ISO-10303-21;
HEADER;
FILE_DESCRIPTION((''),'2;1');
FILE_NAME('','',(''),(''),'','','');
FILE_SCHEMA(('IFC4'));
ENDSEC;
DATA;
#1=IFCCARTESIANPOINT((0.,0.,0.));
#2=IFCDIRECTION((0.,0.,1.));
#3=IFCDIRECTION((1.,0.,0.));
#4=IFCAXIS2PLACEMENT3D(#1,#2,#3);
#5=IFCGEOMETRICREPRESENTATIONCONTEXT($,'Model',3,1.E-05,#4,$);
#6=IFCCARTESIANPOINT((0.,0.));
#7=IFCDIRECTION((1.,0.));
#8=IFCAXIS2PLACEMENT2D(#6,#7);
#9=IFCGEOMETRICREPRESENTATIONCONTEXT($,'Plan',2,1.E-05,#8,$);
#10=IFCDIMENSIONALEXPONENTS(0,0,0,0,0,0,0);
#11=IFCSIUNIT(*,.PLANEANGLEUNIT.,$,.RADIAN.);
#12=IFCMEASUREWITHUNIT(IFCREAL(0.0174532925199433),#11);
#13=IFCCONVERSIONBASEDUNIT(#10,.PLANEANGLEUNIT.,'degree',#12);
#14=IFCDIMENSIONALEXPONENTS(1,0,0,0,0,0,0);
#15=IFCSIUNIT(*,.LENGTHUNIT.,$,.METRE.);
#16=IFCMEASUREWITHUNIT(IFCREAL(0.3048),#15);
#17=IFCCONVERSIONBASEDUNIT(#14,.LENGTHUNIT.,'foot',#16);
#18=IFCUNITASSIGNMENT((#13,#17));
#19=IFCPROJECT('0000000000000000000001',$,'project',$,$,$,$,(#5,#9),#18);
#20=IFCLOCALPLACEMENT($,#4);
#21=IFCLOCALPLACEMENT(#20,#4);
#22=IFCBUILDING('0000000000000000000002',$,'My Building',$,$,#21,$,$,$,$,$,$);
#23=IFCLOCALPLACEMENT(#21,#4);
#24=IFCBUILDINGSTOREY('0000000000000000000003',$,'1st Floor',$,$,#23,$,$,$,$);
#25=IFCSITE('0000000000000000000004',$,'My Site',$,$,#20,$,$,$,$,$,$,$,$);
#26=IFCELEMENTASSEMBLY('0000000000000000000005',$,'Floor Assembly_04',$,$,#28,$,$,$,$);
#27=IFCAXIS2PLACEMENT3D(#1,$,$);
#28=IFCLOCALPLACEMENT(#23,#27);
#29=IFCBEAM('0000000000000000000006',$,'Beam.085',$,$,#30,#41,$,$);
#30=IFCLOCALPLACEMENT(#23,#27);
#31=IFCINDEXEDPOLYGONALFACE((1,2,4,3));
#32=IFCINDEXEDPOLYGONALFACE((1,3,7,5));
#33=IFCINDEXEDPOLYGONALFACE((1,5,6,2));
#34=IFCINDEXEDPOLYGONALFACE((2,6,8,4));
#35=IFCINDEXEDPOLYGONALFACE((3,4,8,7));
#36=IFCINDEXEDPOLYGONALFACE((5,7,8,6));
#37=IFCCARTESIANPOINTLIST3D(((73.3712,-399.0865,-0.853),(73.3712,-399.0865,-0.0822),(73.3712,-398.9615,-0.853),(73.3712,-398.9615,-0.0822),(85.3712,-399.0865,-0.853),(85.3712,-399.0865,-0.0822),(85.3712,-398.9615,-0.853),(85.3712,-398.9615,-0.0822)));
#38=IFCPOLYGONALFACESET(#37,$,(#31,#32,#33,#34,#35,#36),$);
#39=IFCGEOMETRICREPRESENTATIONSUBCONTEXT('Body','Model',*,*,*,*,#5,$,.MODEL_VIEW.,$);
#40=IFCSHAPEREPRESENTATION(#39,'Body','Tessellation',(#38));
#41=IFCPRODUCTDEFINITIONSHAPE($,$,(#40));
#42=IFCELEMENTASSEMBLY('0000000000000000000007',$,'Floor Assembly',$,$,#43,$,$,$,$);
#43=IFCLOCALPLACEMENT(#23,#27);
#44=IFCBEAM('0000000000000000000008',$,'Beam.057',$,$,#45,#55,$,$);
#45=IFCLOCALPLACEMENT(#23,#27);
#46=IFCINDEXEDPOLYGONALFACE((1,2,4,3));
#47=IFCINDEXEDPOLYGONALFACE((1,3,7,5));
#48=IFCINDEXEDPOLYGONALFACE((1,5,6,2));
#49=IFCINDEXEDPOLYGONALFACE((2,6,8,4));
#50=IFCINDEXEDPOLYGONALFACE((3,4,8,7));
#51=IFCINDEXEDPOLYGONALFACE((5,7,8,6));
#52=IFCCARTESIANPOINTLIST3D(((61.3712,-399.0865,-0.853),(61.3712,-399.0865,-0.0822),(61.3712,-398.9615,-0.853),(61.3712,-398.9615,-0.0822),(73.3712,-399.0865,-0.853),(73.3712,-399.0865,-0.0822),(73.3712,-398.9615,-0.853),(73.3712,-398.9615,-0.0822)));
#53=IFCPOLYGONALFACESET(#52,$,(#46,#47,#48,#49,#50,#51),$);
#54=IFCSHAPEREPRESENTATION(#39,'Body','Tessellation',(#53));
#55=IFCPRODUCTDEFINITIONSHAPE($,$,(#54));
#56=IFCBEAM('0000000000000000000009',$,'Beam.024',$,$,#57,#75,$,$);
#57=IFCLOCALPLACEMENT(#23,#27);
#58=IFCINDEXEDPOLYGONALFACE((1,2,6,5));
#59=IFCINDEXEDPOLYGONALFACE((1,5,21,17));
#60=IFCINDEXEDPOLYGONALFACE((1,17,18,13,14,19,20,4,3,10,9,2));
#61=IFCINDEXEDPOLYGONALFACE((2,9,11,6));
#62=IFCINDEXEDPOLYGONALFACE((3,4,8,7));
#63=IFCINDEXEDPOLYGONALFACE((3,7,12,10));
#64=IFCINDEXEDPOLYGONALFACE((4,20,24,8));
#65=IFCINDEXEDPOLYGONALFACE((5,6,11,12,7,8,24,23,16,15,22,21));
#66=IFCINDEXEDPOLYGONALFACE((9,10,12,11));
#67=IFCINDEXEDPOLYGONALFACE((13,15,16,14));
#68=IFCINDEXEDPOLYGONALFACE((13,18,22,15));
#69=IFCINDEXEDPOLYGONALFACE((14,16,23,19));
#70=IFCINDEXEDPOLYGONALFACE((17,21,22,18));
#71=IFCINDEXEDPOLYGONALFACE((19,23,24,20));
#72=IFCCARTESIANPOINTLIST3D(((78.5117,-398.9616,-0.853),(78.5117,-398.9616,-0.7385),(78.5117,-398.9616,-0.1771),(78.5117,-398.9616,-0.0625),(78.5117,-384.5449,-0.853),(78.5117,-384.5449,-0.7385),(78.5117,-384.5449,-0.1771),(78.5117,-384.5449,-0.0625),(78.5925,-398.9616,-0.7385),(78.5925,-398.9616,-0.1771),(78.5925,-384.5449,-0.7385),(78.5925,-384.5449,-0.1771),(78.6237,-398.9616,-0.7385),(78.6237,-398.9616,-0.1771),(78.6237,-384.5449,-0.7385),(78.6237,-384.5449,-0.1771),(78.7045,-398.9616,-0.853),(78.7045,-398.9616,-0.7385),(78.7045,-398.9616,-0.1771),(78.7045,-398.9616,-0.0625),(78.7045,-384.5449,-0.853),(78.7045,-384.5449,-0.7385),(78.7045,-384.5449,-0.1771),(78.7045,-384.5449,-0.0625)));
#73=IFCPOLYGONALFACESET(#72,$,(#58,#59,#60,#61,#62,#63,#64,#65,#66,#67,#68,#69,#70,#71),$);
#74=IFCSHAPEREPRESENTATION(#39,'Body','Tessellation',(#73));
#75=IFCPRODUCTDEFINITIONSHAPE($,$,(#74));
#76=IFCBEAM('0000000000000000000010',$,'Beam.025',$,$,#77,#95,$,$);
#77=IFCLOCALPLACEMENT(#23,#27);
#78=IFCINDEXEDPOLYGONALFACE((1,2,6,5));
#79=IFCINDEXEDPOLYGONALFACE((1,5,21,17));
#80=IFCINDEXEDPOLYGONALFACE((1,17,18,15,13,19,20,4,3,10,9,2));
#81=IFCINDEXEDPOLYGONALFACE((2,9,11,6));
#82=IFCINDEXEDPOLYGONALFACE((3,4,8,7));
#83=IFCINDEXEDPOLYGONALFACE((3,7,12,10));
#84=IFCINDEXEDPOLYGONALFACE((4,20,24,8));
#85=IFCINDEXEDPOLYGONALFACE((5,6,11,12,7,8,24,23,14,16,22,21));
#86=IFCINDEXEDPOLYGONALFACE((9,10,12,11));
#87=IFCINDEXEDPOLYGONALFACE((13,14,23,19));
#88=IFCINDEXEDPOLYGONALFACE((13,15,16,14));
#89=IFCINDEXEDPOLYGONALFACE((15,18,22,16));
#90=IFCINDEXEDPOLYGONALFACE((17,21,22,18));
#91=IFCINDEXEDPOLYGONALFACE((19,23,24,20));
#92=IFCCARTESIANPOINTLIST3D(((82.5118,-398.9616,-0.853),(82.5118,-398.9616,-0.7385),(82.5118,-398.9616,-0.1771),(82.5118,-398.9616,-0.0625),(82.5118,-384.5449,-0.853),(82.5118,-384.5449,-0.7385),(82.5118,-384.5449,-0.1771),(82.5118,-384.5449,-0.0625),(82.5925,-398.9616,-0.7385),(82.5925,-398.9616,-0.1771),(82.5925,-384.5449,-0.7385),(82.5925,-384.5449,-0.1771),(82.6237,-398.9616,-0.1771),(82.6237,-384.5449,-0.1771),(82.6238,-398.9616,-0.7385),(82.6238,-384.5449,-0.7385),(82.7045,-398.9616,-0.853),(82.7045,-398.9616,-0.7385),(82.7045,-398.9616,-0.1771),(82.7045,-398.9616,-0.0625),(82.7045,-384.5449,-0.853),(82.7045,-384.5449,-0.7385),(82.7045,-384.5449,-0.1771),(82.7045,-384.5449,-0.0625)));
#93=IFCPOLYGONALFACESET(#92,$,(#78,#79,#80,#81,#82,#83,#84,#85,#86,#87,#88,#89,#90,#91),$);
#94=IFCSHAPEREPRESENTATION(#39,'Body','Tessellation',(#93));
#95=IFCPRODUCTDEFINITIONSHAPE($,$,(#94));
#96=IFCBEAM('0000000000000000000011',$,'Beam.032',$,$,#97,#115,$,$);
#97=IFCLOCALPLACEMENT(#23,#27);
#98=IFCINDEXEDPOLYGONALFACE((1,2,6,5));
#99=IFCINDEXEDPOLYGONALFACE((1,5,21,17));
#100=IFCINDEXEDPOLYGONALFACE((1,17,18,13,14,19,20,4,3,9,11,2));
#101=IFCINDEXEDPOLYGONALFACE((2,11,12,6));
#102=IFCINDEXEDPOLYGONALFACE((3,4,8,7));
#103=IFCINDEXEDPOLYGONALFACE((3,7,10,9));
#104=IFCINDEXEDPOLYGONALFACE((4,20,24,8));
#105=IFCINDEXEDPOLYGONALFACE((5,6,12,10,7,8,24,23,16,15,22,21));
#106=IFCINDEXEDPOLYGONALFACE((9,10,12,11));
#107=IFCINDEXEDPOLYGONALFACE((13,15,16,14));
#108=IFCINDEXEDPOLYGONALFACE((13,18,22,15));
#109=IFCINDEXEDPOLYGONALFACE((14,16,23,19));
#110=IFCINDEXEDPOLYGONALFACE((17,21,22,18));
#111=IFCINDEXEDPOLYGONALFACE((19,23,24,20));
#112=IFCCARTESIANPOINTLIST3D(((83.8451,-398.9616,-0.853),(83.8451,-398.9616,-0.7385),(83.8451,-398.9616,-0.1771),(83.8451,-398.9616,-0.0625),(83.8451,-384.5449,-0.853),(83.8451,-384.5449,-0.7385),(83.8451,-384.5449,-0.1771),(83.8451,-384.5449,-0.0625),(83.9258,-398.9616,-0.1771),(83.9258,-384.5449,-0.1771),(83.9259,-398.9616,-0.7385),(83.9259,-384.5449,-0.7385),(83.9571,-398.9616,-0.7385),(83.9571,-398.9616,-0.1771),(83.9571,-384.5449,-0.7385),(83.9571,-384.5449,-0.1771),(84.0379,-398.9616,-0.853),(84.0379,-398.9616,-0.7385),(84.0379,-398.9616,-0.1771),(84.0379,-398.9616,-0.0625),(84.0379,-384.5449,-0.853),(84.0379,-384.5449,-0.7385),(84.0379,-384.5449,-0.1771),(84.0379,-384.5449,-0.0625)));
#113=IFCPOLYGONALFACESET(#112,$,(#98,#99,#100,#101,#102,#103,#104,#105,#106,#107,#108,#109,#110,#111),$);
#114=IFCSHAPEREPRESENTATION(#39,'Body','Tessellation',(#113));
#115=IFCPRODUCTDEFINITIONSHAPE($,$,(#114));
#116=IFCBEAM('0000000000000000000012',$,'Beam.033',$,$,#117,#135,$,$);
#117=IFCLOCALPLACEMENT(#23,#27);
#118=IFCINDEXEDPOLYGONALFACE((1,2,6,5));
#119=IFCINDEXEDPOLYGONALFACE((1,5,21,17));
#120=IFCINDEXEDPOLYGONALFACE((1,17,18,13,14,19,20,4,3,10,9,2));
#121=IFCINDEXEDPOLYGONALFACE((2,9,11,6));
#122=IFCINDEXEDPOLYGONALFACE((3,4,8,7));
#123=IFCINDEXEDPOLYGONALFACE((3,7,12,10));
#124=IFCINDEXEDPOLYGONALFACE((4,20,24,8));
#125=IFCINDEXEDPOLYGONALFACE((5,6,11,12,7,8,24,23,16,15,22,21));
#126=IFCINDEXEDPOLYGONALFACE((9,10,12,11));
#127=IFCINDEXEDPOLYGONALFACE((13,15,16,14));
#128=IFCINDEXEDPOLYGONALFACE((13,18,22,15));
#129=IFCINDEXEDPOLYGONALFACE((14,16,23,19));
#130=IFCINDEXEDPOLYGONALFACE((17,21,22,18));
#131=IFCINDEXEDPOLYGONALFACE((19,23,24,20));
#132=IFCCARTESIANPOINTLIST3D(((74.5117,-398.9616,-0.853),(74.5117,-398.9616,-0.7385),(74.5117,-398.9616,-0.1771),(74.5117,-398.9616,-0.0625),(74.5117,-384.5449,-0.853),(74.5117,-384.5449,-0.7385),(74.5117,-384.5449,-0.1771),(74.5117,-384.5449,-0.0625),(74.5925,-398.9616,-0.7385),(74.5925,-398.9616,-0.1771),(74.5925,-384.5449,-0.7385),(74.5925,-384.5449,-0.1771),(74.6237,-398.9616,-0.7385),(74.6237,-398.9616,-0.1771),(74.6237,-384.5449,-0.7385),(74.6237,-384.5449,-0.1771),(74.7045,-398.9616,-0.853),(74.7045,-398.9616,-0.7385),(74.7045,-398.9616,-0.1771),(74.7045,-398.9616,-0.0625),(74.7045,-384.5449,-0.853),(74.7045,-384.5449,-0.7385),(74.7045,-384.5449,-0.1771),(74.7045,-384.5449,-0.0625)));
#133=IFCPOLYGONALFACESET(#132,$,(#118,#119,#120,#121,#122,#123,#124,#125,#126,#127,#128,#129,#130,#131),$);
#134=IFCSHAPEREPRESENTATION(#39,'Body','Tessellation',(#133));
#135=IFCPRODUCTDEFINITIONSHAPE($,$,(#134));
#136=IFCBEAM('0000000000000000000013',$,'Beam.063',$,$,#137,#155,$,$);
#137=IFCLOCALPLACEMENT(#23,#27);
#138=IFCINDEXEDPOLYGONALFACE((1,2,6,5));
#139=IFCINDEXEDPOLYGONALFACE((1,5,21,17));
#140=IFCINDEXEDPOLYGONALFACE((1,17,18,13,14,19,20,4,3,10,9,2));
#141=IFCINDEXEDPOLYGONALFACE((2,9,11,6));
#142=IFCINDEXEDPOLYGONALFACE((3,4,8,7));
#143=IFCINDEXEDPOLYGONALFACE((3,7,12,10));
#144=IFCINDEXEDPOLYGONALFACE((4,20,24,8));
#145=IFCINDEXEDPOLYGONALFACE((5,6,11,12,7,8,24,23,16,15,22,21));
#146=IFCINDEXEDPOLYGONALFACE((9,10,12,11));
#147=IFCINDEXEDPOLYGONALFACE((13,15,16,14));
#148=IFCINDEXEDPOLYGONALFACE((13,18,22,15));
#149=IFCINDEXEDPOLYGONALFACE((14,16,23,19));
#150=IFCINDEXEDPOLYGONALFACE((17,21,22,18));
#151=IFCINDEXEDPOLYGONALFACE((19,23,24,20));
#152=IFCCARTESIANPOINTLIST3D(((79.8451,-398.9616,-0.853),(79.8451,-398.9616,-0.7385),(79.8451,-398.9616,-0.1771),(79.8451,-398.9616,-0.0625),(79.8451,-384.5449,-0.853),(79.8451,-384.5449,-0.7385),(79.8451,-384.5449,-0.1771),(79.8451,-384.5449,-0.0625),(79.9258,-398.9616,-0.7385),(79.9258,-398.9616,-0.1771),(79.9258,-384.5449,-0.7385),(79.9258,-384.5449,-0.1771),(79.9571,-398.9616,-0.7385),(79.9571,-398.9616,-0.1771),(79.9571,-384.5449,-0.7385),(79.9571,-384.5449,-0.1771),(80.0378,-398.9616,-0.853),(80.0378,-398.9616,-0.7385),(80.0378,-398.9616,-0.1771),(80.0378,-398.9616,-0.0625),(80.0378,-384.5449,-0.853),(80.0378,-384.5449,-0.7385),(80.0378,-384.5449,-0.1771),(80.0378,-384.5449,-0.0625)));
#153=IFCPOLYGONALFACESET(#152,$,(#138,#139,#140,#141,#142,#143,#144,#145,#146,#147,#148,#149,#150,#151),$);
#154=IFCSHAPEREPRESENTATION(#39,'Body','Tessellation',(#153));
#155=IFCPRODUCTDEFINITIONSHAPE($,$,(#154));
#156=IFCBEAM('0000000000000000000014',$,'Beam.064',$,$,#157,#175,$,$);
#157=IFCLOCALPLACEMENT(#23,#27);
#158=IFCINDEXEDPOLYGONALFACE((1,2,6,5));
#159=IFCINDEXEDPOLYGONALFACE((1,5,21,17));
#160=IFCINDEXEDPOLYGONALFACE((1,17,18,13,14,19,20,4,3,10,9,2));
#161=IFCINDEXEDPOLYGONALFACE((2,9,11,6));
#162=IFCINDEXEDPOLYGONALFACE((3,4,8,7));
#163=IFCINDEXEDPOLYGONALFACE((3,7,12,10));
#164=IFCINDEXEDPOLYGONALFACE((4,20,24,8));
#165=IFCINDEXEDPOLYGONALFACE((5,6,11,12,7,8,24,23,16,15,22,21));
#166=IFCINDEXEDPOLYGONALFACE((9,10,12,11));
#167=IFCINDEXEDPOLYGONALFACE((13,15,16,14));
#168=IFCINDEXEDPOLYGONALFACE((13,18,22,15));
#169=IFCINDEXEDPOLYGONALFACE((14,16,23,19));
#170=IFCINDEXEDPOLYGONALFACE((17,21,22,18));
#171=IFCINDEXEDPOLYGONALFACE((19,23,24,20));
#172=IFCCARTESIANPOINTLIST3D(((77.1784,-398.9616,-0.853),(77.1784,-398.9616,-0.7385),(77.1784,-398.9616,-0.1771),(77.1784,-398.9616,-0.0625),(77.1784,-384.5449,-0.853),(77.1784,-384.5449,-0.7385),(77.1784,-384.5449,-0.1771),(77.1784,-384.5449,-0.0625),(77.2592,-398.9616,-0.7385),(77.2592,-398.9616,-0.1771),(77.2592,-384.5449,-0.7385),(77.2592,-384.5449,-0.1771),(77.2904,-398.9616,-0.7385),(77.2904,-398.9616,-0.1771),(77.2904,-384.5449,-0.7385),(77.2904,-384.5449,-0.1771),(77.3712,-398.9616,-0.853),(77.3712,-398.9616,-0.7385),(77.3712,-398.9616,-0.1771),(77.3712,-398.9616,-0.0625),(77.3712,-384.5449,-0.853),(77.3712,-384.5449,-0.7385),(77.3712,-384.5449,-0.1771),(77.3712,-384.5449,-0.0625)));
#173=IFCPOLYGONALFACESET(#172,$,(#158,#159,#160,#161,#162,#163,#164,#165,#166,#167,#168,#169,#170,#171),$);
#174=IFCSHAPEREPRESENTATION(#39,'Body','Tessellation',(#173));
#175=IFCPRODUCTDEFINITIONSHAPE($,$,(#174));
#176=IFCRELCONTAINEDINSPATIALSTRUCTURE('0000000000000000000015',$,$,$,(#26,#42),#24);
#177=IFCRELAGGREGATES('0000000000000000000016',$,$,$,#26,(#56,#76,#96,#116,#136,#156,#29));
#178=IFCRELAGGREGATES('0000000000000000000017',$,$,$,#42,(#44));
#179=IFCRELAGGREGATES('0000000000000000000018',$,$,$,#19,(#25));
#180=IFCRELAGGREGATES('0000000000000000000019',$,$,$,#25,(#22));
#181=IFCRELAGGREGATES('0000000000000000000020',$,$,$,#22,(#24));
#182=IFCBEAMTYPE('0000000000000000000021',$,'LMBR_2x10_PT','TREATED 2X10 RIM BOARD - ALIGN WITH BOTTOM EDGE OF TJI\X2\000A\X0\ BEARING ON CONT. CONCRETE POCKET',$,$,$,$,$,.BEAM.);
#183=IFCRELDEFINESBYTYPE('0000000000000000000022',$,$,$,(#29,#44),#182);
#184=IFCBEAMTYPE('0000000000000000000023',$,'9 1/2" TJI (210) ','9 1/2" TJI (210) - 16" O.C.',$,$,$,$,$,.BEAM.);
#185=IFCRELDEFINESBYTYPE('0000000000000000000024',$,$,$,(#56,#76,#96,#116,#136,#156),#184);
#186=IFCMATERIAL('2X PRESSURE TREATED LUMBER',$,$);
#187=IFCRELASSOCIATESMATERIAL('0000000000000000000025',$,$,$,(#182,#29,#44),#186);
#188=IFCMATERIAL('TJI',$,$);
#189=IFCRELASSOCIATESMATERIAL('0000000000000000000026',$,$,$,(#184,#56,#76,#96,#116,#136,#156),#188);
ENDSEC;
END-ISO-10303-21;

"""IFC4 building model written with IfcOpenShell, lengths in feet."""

from ifc_helpers import new_model, entity, si_unit, converted_unit, frame, origin_with_axes, origin_2d_with_axis, place, context, subcontext, project, spatial, indexed_curve, outline, extrude, material, material_profile, profile_set, profile_usage, type_object, element, aggregate, save


model = new_model("IFC4")

# Units and contexts
model_context = context("Model", 3, precision=1e-05, world=origin_with_axes())
plan_context = context("Plan", 2, precision=1e-05, world=origin_2d_with_axis())
body_context = subcontext(model_context, "Body", "Model", "MODEL_VIEW")
ifc_project = project(units=[converted_unit("PLANEANGLEUNIT", "degree", entity("IfcReal", 0.0174532925199433), si_unit("PLANEANGLEUNIT", "RADIAN"), dimensions=[0, 0, 0, 0, 0, 0, 0]), converted_unit("LENGTHUNIT", "foot", entity("IfcReal", 0.3048), si_unit("LENGTHUNIT", "METRE"), dimensions=[1, 0, 0, 0, 0, 0, 0])], contexts=[model_context, plan_context])

# Site, building, storey
site_placement = place(None, origin_with_axes())
site = spatial("IfcSite", under=ifc_project, at=site_placement, Name="My Site")
building_placement = place(site_placement, origin_with_axes())
building = spatial("IfcBuilding", under=site, at=building_placement, Name="My Building")
storey_placement = place(building_placement, origin_with_axes())
storey = spatial("IfcBuildingStorey", under=building, at=storey_placement, Name="1st Floor")

# Element assemblies, beams
assembly_1_placement = place(storey_placement, frame((73.1784, -398.9616, -0.0625), z_axis=(0.0, 0.0, 1.0), x_axis=(0.0, 1.0, 0.0)))
assembly_1 = element("IfcElementAssembly", 1, at=assembly_1_placement, inside=storey, Name="Floor Assembly_04")
ifc_material_1 = material(Name="2X PRESSURE TREATED LUMBER")
ifc_material_profile_1 = material_profile(ifc_material_1, outline(indexed_curve([(-0.0625, 0.3854), (0.0625, 0.3854), (0.0625, -0.3854), (-0.0625, -0.3854), (-0.0625, 0.3854)])))
ifc_profile_set_1 = profile_set([ifc_material_profile_1])
ifc_profile_usage_1 = profile_usage(ifc_profile_set_1, cardinal=5)
beam_type_1 = type_object("IfcBeamType", Name="LMBR_2x10_PT", Description="TREATED 2X10 RIM BOARD - ALIGN WITH BOTTOM EDGE OF TJI\n BEARING ON CONT. CONCRETE POCKET", PredefinedType="BEAM", material=ifc_profile_set_1)
beam_1_placement = place(assembly_1_placement, frame((-0.0625, -12.1928, -0.4051), z_axis=(0.0, 1.0, 0.0), x_axis=(-1.0, 0.0, 0.0)))
beam_1 = element("IfcBeam", 2, at=beam_1_placement, type_object=beam_type_1, material=ifc_profile_usage_1, Name="Beam.085", context=body_context, shape_type="SweptSolid", body=[
    extrude(outline(indexed_curve([(-0.0625, 0.3854), (0.0625, 0.3854), (0.0625, -0.3854), (-0.0625, -0.3854), (-0.0625, 0.3854)])), origin_with_axes(), (0.0, 0.0, 1.0), 12.0),
])
assembly_2_placement = place(storey_placement, frame((61.1784, -398.9616, -0.0625), z_axis=(0.0, 0.0, 1.0), x_axis=(0.0, 1.0, 0.0)))
assembly_2 = element("IfcElementAssembly", 3, at=assembly_2_placement, inside=storey, Name="Floor Assembly")
ifc_profile_usage_2 = profile_usage(ifc_profile_set_1, cardinal=5)
beam_2_placement = place(assembly_2_placement, frame((-0.0625, -12.1928, -0.4051), z_axis=(0.0, 1.0, 0.0), x_axis=(-1.0, 0.0, 0.0)))
beam_2 = element("IfcBeam", 4, at=beam_2_placement, type_object=beam_type_1, material=ifc_profile_usage_2, Name="Beam.057", context=body_context, shape_type="SweptSolid", body=[
    extrude(outline(indexed_curve([(-0.0625, 0.3854), (0.0625, 0.3854), (0.0625, -0.3854), (-0.0625, -0.3854), (-0.0625, 0.3854)])), origin_with_axes(), (0.0, 0.0, 1.0), 12.0),
])

# Beams
ifc_material_2 = material(Name="TJI")
ifc_material_profile_2 = material_profile(ifc_material_2, outline(indexed_curve([(0.0964, 0.7905), (-0.0964, 0.7905), (-0.0964, 0.6759), (-0.0156, 0.6759), (-0.0156, 0.1146), (-0.0964, 0.1146), (-0.0964, 0.0), (0.0964, 0.0), (0.0964, 0.1146), (0.0156, 0.1146), (0.0157, 0.6759), (0.0964, 0.6759), (0.0964, 0.7905)])))
ifc_profile_set_2 = profile_set([ifc_material_profile_2])
ifc_profile_usage_3 = profile_usage(ifc_profile_set_2, cardinal=5)
beam_type_2 = type_object("IfcBeamType", Name="9 1/2\" TJI (210) ", Description="9 1/2\" TJI (210) - 16\" O.C.", PredefinedType="BEAM", material=ifc_profile_set_2)
beam_3_placement = place(assembly_1_placement, frame((0.0, -5.4297, -0.7905), z_axis=(1.0, 0.0, 0.0), x_axis=(0.0, 1.0, 0.0)))
beam_3 = element("IfcBeam", 5, at=beam_3_placement, type_object=beam_type_2, material=ifc_profile_usage_3, Name="Beam.024", context=body_context, shape_type="SweptSolid", body=[
    extrude(outline(indexed_curve([(0.0964, 0.7905), (-0.0964, 0.7905), (-0.0964, 0.6759), (-0.0156, 0.6759), (-0.0156, 0.1146), (-0.0964, 0.1146), (-0.0964, 0.0), (0.0964, 0.0), (0.0964, 0.1146), (0.0156, 0.1146), (0.0157, 0.6759), (0.0964, 0.6759), (0.0964, 0.7905)])), origin_with_axes(), (0.0, 0.0, 1.0), 14.4167),
])
ifc_profile_usage_4 = profile_usage(ifc_profile_set_2, cardinal=5)
beam_4_placement = place(assembly_1_placement, frame((0.0, -9.4297, -0.7905), z_axis=(1.0, 0.0, 0.0), x_axis=(0.0, 1.0, 0.0)))
beam_4 = element("IfcBeam", 6, at=beam_4_placement, type_object=beam_type_2, material=ifc_profile_usage_4, Name="Beam.025", context=body_context, shape_type="SweptSolid", body=[
    extrude(outline(indexed_curve([(0.0964, 0.7905), (-0.0964, 0.7905), (-0.0964, 0.6759), (-0.0156, 0.6759), (-0.0156, 0.1146), (-0.0964, 0.1146), (-0.0964, 0.0), (0.0964, 0.0), (0.0964, 0.1146), (0.0156, 0.1146), (0.0157, 0.6759), (0.0964, 0.6759), (0.0964, 0.7905)])), origin_with_axes(), (0.0, 0.0, 1.0), 14.4167),
])
ifc_profile_usage_5 = profile_usage(ifc_profile_set_2, cardinal=5)
beam_5_placement = place(assembly_1_placement, frame((0.0, -10.7631, -0.7905), z_axis=(1.0, 0.0, 0.0), x_axis=(0.0, 1.0, 0.0)))
beam_5 = element("IfcBeam", 7, at=beam_5_placement, type_object=beam_type_2, material=ifc_profile_usage_5, Name="Beam.032", context=body_context, shape_type="SweptSolid", body=[
    extrude(outline(indexed_curve([(0.0964, 0.7905), (-0.0964, 0.7905), (-0.0964, 0.6759), (-0.0156, 0.6759), (-0.0156, 0.1146), (-0.0964, 0.1146), (-0.0964, 0.0), (0.0964, 0.0), (0.0964, 0.1146), (0.0156, 0.1146), (0.0157, 0.6759), (0.0964, 0.6759), (0.0964, 0.7905)])), origin_with_axes(), (0.0, 0.0, 1.0), 14.4167),
])
ifc_profile_usage_6 = profile_usage(ifc_profile_set_2, cardinal=5)
beam_6_placement = place(assembly_1_placement, frame((0.0, -1.4297, -0.7905), z_axis=(1.0, 0.0, 0.0), x_axis=(0.0, 1.0, 0.0)))
beam_6 = element("IfcBeam", 8, at=beam_6_placement, type_object=beam_type_2, material=ifc_profile_usage_6, Name="Beam.033", context=body_context, shape_type="SweptSolid", body=[
    extrude(outline(indexed_curve([(0.0964, 0.7905), (-0.0964, 0.7905), (-0.0964, 0.6759), (-0.0156, 0.6759), (-0.0156, 0.1146), (-0.0964, 0.1146), (-0.0964, 0.0), (0.0964, 0.0), (0.0964, 0.1146), (0.0156, 0.1146), (0.0157, 0.6759), (0.0964, 0.6759), (0.0964, 0.7905)])), origin_with_axes(), (0.0, 0.0, 1.0), 14.4167),
])
ifc_profile_usage_7 = profile_usage(ifc_profile_set_2, cardinal=5)
beam_7_placement = place(assembly_1_placement, frame((0.0, -6.763, -0.7905), z_axis=(1.0, 0.0, 0.0), x_axis=(0.0, 1.0, 0.0)))
beam_7 = element("IfcBeam", 9, at=beam_7_placement, type_object=beam_type_2, material=ifc_profile_usage_7, Name="Beam.063", context=body_context, shape_type="SweptSolid", body=[
    extrude(outline(indexed_curve([(0.0964, 0.7905), (-0.0964, 0.7905), (-0.0964, 0.6759), (-0.0156, 0.6759), (-0.0156, 0.1146), (-0.0964, 0.1146), (-0.0964, 0.0), (0.0964, 0.0), (0.0964, 0.1146), (0.0156, 0.1146), (0.0157, 0.6759), (0.0964, 0.6759), (0.0964, 0.7905)])), origin_with_axes(), (0.0, 0.0, 1.0), 14.4167),
])
ifc_profile_usage_8 = profile_usage(ifc_profile_set_2, cardinal=5)
beam_8_placement = place(assembly_1_placement, frame((0.0, -4.0964, -0.7905), z_axis=(1.0, 0.0, 0.0), x_axis=(0.0, 1.0, 0.0)))
beam_8 = element("IfcBeam", 10, at=beam_8_placement, type_object=beam_type_2, material=ifc_profile_usage_8, Name="Beam.064", context=body_context, shape_type="SweptSolid", body=[
    extrude(outline(indexed_curve([(0.0964, 0.7905), (-0.0964, 0.7905), (-0.0964, 0.6759), (-0.0156, 0.6759), (-0.0156, 0.1146), (-0.0964, 0.1146), (-0.0964, 0.0), (0.0964, 0.0), (0.0964, 0.1146), (0.0156, 0.1146), (0.0157, 0.6759), (0.0964, 0.6759), (0.0964, 0.7905)])), origin_with_axes(), (0.0, 0.0, 1.0), 14.4167),
])
aggregate(assembly_1, [beam_3, beam_4, beam_5, beam_6, beam_7, beam_8, beam_1])
aggregate(assembly_2, [beam_2])

save(model, "model.ifc")
